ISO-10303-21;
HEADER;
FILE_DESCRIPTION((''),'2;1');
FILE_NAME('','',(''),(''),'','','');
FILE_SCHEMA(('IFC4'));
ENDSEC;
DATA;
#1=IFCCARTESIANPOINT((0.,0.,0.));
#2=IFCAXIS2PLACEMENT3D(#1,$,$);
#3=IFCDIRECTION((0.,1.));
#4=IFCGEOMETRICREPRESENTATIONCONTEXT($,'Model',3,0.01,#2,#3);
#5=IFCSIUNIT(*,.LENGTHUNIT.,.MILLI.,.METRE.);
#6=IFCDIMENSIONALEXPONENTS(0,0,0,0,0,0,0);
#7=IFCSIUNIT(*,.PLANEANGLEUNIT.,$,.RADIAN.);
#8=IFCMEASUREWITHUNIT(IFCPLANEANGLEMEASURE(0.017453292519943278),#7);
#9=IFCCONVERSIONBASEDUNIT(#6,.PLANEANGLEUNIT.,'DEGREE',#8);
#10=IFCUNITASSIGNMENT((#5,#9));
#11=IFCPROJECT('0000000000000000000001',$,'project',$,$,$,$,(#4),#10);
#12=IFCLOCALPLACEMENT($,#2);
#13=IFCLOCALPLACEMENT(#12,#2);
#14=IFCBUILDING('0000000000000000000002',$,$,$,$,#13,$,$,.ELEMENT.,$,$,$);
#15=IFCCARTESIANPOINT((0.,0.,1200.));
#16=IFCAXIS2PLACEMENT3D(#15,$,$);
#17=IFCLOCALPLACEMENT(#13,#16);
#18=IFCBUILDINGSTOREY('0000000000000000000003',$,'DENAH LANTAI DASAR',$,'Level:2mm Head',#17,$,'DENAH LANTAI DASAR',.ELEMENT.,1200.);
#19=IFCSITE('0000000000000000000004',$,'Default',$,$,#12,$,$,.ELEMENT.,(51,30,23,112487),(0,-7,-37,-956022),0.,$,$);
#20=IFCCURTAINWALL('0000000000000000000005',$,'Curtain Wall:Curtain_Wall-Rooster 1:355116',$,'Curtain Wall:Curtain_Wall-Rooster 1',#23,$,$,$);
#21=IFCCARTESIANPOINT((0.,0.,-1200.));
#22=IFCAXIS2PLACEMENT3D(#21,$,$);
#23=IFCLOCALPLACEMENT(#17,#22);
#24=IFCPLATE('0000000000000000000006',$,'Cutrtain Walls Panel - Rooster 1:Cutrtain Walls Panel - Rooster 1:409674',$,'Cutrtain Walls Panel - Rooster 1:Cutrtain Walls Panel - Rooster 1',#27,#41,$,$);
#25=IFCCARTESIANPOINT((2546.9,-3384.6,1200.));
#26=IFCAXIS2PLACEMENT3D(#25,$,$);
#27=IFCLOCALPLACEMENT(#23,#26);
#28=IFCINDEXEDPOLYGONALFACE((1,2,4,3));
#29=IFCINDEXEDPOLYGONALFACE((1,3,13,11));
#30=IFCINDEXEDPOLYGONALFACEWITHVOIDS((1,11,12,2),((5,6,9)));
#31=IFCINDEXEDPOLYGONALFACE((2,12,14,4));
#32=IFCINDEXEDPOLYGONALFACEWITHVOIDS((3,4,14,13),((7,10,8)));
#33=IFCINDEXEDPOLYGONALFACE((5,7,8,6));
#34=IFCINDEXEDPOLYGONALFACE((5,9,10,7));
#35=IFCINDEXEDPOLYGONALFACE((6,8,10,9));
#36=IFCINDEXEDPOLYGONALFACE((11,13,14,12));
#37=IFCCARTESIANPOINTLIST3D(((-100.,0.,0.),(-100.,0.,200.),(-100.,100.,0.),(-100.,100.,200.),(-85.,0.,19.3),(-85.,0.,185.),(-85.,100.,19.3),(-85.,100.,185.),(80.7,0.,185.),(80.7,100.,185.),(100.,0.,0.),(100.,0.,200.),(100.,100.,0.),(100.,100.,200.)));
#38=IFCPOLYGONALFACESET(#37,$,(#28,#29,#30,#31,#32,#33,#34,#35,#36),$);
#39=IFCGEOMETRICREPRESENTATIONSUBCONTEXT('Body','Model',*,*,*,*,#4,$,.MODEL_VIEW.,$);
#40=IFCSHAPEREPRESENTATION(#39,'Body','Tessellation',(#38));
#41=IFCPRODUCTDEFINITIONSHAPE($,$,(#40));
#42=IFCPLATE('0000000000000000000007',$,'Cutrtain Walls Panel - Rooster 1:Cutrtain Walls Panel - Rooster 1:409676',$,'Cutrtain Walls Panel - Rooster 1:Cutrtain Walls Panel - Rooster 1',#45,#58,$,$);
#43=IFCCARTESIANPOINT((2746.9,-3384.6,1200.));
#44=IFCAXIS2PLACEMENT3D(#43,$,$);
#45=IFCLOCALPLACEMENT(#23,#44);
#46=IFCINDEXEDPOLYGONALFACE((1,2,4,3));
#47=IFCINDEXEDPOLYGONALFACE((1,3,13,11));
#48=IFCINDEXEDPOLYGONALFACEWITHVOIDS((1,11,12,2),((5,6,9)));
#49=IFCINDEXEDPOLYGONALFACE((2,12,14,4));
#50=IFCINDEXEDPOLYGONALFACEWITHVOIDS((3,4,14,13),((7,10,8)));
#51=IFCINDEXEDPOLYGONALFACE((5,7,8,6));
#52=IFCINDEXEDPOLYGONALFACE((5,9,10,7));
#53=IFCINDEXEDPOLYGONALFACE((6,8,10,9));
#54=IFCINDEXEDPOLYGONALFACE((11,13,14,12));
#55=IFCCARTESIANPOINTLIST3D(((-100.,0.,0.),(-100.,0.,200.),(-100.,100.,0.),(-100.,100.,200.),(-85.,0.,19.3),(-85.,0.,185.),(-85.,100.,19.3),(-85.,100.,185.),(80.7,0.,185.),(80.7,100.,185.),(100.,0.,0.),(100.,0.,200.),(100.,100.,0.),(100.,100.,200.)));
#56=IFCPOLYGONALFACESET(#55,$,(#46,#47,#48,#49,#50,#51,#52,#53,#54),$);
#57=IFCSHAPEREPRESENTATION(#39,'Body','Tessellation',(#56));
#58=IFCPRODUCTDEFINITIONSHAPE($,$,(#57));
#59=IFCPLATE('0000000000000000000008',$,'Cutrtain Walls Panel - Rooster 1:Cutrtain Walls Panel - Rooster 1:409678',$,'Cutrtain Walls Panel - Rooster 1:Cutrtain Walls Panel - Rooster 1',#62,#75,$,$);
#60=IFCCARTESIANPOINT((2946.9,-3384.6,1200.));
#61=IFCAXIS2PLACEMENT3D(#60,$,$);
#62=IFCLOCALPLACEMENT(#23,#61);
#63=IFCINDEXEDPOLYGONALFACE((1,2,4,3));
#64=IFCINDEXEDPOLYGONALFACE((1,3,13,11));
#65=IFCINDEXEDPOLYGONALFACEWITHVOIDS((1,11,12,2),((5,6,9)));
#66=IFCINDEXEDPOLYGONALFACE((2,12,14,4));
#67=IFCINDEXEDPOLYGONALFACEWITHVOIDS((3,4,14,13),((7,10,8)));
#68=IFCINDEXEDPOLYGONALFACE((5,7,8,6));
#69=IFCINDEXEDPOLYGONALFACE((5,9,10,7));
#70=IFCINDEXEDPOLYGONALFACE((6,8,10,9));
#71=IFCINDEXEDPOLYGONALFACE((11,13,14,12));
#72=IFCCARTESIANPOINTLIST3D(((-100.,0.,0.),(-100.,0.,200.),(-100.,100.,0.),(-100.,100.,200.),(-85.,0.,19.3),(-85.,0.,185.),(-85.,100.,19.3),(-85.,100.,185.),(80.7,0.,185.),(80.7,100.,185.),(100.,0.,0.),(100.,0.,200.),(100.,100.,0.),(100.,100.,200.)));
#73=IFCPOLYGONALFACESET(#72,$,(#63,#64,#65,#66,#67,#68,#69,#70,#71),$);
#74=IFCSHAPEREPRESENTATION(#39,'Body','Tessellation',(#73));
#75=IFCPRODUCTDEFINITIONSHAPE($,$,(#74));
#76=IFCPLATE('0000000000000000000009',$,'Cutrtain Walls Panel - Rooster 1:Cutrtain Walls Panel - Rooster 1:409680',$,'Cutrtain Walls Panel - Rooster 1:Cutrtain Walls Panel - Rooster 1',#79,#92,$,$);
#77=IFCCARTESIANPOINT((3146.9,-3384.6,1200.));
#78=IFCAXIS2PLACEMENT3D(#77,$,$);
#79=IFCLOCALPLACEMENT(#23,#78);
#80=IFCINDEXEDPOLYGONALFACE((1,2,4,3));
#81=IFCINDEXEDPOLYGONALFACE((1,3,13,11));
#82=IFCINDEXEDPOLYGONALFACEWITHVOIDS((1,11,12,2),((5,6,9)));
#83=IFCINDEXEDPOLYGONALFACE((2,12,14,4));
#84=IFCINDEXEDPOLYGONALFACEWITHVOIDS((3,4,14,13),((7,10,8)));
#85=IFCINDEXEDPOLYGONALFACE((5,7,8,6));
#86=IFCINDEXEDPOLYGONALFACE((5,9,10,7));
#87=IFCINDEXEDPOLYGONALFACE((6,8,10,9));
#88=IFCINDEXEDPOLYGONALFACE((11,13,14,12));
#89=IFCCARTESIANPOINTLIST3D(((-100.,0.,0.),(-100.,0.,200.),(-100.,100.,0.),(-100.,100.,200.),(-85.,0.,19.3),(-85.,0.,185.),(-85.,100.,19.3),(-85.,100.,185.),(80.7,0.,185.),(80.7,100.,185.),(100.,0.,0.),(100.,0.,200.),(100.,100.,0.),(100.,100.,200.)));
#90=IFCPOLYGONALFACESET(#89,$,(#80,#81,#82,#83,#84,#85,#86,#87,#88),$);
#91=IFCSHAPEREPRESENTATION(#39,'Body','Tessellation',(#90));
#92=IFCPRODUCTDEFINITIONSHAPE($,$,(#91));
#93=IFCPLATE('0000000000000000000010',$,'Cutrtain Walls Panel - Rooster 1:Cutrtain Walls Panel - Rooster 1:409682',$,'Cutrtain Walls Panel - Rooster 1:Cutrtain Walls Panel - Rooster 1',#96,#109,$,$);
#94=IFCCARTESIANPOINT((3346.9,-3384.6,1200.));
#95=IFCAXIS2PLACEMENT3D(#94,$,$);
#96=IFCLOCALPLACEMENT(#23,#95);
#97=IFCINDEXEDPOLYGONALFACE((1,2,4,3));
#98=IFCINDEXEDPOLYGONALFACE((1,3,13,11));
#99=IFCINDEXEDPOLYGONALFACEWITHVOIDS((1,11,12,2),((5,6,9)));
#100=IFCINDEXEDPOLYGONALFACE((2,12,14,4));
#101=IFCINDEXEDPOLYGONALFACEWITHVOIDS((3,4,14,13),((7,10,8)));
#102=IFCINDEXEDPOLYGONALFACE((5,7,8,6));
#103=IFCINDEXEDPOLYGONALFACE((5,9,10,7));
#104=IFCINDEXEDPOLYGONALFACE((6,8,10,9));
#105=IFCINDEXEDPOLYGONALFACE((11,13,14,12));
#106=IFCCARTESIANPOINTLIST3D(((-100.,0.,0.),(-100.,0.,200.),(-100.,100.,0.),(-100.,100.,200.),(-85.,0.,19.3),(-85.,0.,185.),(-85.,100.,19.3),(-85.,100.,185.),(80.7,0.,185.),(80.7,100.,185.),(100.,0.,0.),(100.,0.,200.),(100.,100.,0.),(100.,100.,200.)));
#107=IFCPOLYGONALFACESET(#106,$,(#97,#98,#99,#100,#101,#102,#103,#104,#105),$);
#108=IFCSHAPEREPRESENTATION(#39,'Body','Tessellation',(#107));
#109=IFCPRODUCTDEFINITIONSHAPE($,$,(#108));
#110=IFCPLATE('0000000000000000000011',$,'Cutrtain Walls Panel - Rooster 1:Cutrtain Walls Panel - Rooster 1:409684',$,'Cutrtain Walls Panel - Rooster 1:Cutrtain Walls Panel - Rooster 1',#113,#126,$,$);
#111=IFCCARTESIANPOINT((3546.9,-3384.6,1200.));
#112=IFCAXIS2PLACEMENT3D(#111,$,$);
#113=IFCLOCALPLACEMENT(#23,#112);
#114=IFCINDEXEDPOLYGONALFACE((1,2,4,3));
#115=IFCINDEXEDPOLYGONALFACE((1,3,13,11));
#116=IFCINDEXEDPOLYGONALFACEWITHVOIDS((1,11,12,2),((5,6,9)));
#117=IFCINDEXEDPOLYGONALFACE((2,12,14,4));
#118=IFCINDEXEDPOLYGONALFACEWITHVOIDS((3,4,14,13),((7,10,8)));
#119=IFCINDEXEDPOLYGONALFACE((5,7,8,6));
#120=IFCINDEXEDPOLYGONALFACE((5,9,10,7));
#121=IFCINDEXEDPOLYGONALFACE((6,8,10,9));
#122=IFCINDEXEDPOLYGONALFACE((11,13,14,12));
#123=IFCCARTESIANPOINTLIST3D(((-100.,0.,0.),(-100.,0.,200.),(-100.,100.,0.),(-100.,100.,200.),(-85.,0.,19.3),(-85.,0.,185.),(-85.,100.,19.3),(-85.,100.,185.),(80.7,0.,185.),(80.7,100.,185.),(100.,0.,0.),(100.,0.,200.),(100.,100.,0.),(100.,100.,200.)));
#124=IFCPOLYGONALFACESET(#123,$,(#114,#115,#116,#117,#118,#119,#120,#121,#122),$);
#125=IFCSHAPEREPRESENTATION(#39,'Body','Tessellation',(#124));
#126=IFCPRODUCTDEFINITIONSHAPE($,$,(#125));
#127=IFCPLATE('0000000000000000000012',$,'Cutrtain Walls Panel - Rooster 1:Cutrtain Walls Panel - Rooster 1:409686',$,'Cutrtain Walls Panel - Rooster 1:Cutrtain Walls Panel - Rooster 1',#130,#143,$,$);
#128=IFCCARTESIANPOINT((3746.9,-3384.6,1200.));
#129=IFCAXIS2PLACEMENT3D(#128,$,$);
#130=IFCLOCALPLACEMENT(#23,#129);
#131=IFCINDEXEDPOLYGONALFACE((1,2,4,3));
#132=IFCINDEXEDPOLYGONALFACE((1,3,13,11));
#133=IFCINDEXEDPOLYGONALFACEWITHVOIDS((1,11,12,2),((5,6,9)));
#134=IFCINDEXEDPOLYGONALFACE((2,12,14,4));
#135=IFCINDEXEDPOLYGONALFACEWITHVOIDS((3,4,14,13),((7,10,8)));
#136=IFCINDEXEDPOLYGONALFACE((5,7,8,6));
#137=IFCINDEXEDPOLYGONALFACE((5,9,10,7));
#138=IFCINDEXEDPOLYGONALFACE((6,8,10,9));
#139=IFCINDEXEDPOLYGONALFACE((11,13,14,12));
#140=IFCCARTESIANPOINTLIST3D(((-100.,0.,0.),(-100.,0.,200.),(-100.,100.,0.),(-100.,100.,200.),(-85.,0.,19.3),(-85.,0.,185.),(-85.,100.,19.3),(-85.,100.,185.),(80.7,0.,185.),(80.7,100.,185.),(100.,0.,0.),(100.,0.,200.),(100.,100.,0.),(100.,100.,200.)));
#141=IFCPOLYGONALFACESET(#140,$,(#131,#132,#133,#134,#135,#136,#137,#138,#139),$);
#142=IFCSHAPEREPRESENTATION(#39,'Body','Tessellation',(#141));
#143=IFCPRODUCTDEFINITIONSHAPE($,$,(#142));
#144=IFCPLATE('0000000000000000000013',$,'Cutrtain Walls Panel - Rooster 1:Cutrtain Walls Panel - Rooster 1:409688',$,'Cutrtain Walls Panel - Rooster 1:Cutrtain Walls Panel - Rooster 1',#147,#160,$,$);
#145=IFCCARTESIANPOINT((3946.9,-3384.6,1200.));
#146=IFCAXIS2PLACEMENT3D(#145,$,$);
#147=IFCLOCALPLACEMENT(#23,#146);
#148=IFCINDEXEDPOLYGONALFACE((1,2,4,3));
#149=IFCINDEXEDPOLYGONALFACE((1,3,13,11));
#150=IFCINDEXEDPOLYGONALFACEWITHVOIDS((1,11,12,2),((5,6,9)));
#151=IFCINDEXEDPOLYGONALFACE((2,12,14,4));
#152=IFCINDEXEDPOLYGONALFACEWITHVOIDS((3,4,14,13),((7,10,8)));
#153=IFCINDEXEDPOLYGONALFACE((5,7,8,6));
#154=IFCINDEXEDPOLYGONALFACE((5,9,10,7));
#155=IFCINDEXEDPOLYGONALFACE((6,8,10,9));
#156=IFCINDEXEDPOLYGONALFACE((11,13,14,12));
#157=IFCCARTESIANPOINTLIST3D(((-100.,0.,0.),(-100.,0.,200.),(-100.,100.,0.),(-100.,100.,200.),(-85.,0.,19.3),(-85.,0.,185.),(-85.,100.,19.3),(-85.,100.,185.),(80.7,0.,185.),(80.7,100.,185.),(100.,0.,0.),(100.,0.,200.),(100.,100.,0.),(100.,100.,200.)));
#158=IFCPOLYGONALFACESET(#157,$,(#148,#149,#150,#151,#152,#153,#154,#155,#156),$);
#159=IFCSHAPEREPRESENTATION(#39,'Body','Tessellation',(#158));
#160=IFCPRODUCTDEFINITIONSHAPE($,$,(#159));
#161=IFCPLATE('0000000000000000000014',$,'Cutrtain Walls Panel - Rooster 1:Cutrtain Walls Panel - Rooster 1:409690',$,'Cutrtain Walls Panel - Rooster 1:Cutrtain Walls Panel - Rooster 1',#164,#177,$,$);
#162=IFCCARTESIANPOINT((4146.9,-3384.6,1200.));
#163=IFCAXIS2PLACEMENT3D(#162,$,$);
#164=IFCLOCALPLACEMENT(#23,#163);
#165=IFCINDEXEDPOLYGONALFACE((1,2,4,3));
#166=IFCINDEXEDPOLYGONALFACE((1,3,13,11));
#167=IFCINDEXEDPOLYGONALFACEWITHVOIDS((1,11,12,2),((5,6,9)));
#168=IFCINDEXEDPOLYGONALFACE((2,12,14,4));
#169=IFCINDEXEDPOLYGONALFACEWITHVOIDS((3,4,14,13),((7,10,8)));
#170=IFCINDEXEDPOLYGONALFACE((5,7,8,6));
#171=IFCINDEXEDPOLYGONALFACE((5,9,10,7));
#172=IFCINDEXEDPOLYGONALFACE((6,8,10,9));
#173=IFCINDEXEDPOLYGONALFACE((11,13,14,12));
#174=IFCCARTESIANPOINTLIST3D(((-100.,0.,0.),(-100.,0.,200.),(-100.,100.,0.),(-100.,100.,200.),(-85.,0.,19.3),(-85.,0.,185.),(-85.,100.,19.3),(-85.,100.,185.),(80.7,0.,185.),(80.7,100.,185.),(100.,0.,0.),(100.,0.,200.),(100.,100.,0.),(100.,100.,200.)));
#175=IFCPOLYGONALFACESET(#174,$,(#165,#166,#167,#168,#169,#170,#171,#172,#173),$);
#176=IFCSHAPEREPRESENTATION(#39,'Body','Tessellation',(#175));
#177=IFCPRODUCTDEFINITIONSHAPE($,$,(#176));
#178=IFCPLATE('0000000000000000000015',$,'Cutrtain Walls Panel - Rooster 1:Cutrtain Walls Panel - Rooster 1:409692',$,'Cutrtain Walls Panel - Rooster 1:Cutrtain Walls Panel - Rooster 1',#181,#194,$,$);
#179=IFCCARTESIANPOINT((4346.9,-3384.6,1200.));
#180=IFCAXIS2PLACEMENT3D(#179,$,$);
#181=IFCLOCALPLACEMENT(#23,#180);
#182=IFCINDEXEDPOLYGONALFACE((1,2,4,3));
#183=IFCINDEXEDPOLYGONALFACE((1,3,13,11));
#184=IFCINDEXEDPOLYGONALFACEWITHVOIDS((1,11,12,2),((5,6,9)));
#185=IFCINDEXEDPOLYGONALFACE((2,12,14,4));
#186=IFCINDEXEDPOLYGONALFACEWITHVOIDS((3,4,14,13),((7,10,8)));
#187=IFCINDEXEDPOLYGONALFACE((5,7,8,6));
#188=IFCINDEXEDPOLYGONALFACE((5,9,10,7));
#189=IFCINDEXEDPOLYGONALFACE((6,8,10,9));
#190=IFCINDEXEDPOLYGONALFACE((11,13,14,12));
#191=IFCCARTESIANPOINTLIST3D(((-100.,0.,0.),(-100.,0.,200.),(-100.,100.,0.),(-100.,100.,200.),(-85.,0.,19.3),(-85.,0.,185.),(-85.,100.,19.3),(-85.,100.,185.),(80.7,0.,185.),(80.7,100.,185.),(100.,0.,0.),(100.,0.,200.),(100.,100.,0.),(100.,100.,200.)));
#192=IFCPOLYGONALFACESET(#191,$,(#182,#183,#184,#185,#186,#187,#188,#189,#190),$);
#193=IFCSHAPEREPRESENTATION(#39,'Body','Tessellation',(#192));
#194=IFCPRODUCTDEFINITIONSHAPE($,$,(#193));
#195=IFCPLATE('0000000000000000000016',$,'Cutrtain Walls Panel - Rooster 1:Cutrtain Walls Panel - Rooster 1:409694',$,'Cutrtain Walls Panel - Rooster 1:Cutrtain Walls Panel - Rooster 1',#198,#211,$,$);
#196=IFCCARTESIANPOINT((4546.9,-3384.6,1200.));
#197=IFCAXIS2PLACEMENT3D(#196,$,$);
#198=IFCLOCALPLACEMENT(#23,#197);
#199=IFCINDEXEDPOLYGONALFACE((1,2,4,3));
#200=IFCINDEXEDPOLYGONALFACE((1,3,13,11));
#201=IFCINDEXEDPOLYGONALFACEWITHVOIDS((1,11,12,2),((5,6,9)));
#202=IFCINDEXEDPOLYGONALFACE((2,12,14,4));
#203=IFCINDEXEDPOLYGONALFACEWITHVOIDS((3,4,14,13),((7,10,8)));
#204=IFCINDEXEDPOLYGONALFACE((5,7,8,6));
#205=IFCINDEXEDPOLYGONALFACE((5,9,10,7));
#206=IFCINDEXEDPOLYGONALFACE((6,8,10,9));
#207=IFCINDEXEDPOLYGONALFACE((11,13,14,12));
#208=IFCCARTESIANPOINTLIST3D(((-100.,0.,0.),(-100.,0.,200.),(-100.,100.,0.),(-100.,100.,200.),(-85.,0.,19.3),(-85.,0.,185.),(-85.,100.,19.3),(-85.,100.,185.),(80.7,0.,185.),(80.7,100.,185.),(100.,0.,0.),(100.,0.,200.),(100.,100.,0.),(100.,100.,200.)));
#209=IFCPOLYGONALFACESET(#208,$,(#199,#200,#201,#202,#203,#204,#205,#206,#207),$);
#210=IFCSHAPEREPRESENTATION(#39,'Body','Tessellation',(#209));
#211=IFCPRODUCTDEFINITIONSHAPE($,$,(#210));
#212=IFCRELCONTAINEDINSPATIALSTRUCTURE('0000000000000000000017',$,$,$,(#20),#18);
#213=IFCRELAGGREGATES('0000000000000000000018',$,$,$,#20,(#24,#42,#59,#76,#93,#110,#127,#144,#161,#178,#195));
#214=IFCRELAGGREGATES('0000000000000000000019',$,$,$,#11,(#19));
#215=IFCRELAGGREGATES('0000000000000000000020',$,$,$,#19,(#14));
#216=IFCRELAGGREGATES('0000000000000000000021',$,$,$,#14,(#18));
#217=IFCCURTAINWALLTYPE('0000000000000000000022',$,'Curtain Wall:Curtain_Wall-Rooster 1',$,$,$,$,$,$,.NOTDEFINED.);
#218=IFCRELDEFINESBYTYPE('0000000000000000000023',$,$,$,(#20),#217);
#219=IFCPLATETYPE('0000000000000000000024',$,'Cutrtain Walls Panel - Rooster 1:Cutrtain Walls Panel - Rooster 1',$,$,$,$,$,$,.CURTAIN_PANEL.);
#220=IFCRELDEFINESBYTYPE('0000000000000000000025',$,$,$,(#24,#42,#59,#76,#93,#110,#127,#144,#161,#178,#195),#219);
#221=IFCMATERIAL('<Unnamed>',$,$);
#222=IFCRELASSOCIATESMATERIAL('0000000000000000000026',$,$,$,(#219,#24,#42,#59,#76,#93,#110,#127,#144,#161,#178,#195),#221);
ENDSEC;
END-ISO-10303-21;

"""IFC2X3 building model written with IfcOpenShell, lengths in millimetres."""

from ifc_helpers import new_model, entity, si_unit, converted_unit, direction, frame, origin, place, context, subcontext, project, spatial, polyline, outline, extrude, source, transform, mapped, material, type_object, type_shapes, element, aggregate, save


model = new_model("IFC2X3")

# Units and contexts
model_context = context("Model", 3, precision=0.01, world=origin(), true_north=direction((0.0, 1.0)))
body_context = subcontext(model_context, "Body", "Model", "MODEL_VIEW")
ifc_project = project(units=[si_unit("LENGTHUNIT", "METRE", prefix="MILLI"), converted_unit("PLANEANGLEUNIT", "DEGREE", entity("IfcPlaneAngleMeasure", 0.017453292519943278), si_unit("PLANEANGLEUNIT", "RADIAN"), dimensions=[0, 0, 0, 0, 0, 0, 0])], contexts=[model_context])

# Site, building, storey
site_placement = place(None, origin())
site = spatial("IfcSite", under=ifc_project, at=site_placement, Name="Default", CompositionType="ELEMENT", RefLatitude=(51, 30, 23, 112487), RefLongitude=(0, -7, -37, -956022), RefElevation=0.0)
building_placement = place(site_placement, origin())
building = spatial("IfcBuilding", under=site, at=building_placement, CompositionType="ELEMENT")
storey_placement = place(building_placement, frame((0.0, 0.0, 1200.0)))
storey = spatial("IfcBuildingStorey", under=building, at=storey_placement, Name="DENAH LANTAI DASAR", ObjectType="Level:2mm Head", LongName="DENAH LANTAI DASAR", CompositionType="ELEMENT", Elevation=1200.0)

# Curtain wall, plates
curtain_wall_type = type_object("IfcCurtainWallType", Name="Curtain Wall:Curtain_Wall-Rooster 1", PredefinedType="NOTDEFINED")
curtain_wall_placement = place(storey_placement, frame((0.0, 0.0, -1200.0)))
curtain_wall = element("IfcCurtainWall", 1, at=curtain_wall_placement, inside=storey, type_object=curtain_wall_type, Name="Curtain Wall:Curtain_Wall-Rooster 1:355116", ObjectType="Curtain Wall:Curtain_Wall-Rooster 1")
ifc_material = material(Name="<Unnamed>")
plate_type_1 = type_object("IfcPlateType", Name="Cutrtain Walls Panel - Rooster 1:Cutrtain Walls Panel - Rooster 1", PredefinedType="CURTAIN_PANEL", material=ifc_material)
shared_shape_1 = source(origin(), body_context, "Body", "SweptSolid", [
    extrude(outline(polyline([(-100.0, -100.0), (100.0, -100.0), (100.0, 100.0), (-100.0, 100.0), (-100.0, -100.0)]), holes=[polyline([(80.7, 85.0), (-85.0, -80.7), (-85.0, 85.0), (80.7, 85.0)])]), frame((0.0, 0.0, 100.0), z_axis=(0.0, 1.0, 0.0), x_axis=(0.0, 0.0, -1.0)), (0.0, 0.0, 1.0), 100.0),
])
type_shapes(plate_type_1, [shared_shape_1])
plate_1_placement = place(curtain_wall_placement, frame((2546.9, -3384.6, 1200.0)))
plate_1 = element("IfcPlate", 2, at=plate_1_placement, type_object=plate_type_1, material=ifc_material, Name="Cutrtain Walls Panel - Rooster 1:Cutrtain Walls Panel - Rooster 1:409674", ObjectType="Cutrtain Walls Panel - Rooster 1:Cutrtain Walls Panel - Rooster 1", context=body_context, shape_type="MappedRepresentation", body=[
    mapped(shared_shape_1, transform((0.0, 0.0, 0.0), scale=1.0)),
])
plate_2_placement = place(curtain_wall_placement, frame((2746.9, -3384.6, 1200.0)))
plate_2 = element("IfcPlate", 3, at=plate_2_placement, type_object=plate_type_1, material=ifc_material, Name="Cutrtain Walls Panel - Rooster 1:Cutrtain Walls Panel - Rooster 1:409676", ObjectType="Cutrtain Walls Panel - Rooster 1:Cutrtain Walls Panel - Rooster 1", context=body_context, shape_type="MappedRepresentation", body=[
    mapped(shared_shape_1, transform((0.0, 0.0, 0.0), scale=1.0)),
])
plate_3_placement = place(curtain_wall_placement, frame((2946.9, -3384.6, 1200.0)))
plate_3 = element("IfcPlate", 4, at=plate_3_placement, type_object=plate_type_1, material=ifc_material, Name="Cutrtain Walls Panel - Rooster 1:Cutrtain Walls Panel - Rooster 1:409678", ObjectType="Cutrtain Walls Panel - Rooster 1:Cutrtain Walls Panel - Rooster 1", context=body_context, shape_type="MappedRepresentation", body=[
    mapped(shared_shape_1, transform((0.0, 0.0, 0.0), scale=1.0)),
])
plate_4_placement = place(curtain_wall_placement, frame((3146.9, -3384.6, 1200.0)))
plate_4 = element("IfcPlate", 5, at=plate_4_placement, type_object=plate_type_1, material=ifc_material, Name="Cutrtain Walls Panel - Rooster 1:Cutrtain Walls Panel - Rooster 1:409680", ObjectType="Cutrtain Walls Panel - Rooster 1:Cutrtain Walls Panel - Rooster 1", context=body_context, shape_type="MappedRepresentation", body=[
    mapped(shared_shape_1, transform((0.0, 0.0, 0.0), scale=1.0)),
])
plate_5_placement = place(curtain_wall_placement, frame((3346.9, -3384.6, 1200.0)))
plate_5 = element("IfcPlate", 6, at=plate_5_placement, type_object=plate_type_1, material=ifc_material, Name="Cutrtain Walls Panel - Rooster 1:Cutrtain Walls Panel - Rooster 1:409682", ObjectType="Cutrtain Walls Panel - Rooster 1:Cutrtain Walls Panel - Rooster 1", context=body_context, shape_type="MappedRepresentation", body=[
    mapped(shared_shape_1, transform((0.0, 0.0, 0.0), scale=1.0)),
])
plate_6_placement = place(curtain_wall_placement, frame((3546.9, -3384.6, 1200.0)))
plate_6 = element("IfcPlate", 7, at=plate_6_placement, type_object=plate_type_1, material=ifc_material, Name="Cutrtain Walls Panel - Rooster 1:Cutrtain Walls Panel - Rooster 1:409684", ObjectType="Cutrtain Walls Panel - Rooster 1:Cutrtain Walls Panel - Rooster 1", context=body_context, shape_type="MappedRepresentation", body=[
    mapped(shared_shape_1, transform((0.0, 0.0, 0.0), scale=1.0)),
])
plate_7_placement = place(curtain_wall_placement, frame((3746.9, -3384.6, 1200.0)))
plate_7 = element("IfcPlate", 8, at=plate_7_placement, type_object=plate_type_1, material=ifc_material, Name="Cutrtain Walls Panel - Rooster 1:Cutrtain Walls Panel - Rooster 1:409686", ObjectType="Cutrtain Walls Panel - Rooster 1:Cutrtain Walls Panel - Rooster 1", context=body_context, shape_type="MappedRepresentation", body=[
    mapped(shared_shape_1, transform((0.0, 0.0, 0.0), scale=1.0)),
])
plate_8_placement = place(curtain_wall_placement, frame((3946.9, -3384.6, 1200.0)))
plate_8 = element("IfcPlate", 9, at=plate_8_placement, type_object=plate_type_1, material=ifc_material, Name="Cutrtain Walls Panel - Rooster 1:Cutrtain Walls Panel - Rooster 1:409688", ObjectType="Cutrtain Walls Panel - Rooster 1:Cutrtain Walls Panel - Rooster 1", context=body_context, shape_type="MappedRepresentation", body=[
    mapped(shared_shape_1, transform((0.0, 0.0, 0.0), scale=1.0)),
])
plate_9_placement = place(curtain_wall_placement, frame((4146.9, -3384.6, 1200.0)))
plate_9 = element("IfcPlate", 10, at=plate_9_placement, type_object=plate_type_1, material=ifc_material, Name="Cutrtain Walls Panel - Rooster 1:Cutrtain Walls Panel - Rooster 1:409690", ObjectType="Cutrtain Walls Panel - Rooster 1:Cutrtain Walls Panel - Rooster 1", context=body_context, shape_type="MappedRepresentation", body=[
    mapped(shared_shape_1, transform((0.0, 0.0, 0.0), scale=1.0)),
])
plate_10_placement = place(curtain_wall_placement, frame((4346.9, -3384.6, 1200.0)))
plate_10 = element("IfcPlate", 11, at=plate_10_placement, type_object=plate_type_1, material=ifc_material, Name="Cutrtain Walls Panel - Rooster 1:Cutrtain Walls Panel - Rooster 1:409692", ObjectType="Cutrtain Walls Panel - Rooster 1:Cutrtain Walls Panel - Rooster 1", context=body_context, shape_type="MappedRepresentation", body=[
    mapped(shared_shape_1, transform((0.0, 0.0, 0.0), scale=1.0)),
])
plate_11_placement = place(curtain_wall_placement, frame((4546.9, -3384.6, 1200.0)))
plate_11 = element("IfcPlate", 12, at=plate_11_placement, type_object=plate_type_1, material=ifc_material, Name="Cutrtain Walls Panel - Rooster 1:Cutrtain Walls Panel - Rooster 1:409694", ObjectType="Cutrtain Walls Panel - Rooster 1:Cutrtain Walls Panel - Rooster 1", context=body_context, shape_type="MappedRepresentation", body=[
    mapped(shared_shape_1, transform((0.0, 0.0, 0.0), scale=1.0)),
])
aggregate(curtain_wall, [plate_1, plate_2, plate_3, plate_4, plate_5, plate_6, plate_7, plate_8, plate_9, plate_10, plate_11])

save(model, "model.ifc")
